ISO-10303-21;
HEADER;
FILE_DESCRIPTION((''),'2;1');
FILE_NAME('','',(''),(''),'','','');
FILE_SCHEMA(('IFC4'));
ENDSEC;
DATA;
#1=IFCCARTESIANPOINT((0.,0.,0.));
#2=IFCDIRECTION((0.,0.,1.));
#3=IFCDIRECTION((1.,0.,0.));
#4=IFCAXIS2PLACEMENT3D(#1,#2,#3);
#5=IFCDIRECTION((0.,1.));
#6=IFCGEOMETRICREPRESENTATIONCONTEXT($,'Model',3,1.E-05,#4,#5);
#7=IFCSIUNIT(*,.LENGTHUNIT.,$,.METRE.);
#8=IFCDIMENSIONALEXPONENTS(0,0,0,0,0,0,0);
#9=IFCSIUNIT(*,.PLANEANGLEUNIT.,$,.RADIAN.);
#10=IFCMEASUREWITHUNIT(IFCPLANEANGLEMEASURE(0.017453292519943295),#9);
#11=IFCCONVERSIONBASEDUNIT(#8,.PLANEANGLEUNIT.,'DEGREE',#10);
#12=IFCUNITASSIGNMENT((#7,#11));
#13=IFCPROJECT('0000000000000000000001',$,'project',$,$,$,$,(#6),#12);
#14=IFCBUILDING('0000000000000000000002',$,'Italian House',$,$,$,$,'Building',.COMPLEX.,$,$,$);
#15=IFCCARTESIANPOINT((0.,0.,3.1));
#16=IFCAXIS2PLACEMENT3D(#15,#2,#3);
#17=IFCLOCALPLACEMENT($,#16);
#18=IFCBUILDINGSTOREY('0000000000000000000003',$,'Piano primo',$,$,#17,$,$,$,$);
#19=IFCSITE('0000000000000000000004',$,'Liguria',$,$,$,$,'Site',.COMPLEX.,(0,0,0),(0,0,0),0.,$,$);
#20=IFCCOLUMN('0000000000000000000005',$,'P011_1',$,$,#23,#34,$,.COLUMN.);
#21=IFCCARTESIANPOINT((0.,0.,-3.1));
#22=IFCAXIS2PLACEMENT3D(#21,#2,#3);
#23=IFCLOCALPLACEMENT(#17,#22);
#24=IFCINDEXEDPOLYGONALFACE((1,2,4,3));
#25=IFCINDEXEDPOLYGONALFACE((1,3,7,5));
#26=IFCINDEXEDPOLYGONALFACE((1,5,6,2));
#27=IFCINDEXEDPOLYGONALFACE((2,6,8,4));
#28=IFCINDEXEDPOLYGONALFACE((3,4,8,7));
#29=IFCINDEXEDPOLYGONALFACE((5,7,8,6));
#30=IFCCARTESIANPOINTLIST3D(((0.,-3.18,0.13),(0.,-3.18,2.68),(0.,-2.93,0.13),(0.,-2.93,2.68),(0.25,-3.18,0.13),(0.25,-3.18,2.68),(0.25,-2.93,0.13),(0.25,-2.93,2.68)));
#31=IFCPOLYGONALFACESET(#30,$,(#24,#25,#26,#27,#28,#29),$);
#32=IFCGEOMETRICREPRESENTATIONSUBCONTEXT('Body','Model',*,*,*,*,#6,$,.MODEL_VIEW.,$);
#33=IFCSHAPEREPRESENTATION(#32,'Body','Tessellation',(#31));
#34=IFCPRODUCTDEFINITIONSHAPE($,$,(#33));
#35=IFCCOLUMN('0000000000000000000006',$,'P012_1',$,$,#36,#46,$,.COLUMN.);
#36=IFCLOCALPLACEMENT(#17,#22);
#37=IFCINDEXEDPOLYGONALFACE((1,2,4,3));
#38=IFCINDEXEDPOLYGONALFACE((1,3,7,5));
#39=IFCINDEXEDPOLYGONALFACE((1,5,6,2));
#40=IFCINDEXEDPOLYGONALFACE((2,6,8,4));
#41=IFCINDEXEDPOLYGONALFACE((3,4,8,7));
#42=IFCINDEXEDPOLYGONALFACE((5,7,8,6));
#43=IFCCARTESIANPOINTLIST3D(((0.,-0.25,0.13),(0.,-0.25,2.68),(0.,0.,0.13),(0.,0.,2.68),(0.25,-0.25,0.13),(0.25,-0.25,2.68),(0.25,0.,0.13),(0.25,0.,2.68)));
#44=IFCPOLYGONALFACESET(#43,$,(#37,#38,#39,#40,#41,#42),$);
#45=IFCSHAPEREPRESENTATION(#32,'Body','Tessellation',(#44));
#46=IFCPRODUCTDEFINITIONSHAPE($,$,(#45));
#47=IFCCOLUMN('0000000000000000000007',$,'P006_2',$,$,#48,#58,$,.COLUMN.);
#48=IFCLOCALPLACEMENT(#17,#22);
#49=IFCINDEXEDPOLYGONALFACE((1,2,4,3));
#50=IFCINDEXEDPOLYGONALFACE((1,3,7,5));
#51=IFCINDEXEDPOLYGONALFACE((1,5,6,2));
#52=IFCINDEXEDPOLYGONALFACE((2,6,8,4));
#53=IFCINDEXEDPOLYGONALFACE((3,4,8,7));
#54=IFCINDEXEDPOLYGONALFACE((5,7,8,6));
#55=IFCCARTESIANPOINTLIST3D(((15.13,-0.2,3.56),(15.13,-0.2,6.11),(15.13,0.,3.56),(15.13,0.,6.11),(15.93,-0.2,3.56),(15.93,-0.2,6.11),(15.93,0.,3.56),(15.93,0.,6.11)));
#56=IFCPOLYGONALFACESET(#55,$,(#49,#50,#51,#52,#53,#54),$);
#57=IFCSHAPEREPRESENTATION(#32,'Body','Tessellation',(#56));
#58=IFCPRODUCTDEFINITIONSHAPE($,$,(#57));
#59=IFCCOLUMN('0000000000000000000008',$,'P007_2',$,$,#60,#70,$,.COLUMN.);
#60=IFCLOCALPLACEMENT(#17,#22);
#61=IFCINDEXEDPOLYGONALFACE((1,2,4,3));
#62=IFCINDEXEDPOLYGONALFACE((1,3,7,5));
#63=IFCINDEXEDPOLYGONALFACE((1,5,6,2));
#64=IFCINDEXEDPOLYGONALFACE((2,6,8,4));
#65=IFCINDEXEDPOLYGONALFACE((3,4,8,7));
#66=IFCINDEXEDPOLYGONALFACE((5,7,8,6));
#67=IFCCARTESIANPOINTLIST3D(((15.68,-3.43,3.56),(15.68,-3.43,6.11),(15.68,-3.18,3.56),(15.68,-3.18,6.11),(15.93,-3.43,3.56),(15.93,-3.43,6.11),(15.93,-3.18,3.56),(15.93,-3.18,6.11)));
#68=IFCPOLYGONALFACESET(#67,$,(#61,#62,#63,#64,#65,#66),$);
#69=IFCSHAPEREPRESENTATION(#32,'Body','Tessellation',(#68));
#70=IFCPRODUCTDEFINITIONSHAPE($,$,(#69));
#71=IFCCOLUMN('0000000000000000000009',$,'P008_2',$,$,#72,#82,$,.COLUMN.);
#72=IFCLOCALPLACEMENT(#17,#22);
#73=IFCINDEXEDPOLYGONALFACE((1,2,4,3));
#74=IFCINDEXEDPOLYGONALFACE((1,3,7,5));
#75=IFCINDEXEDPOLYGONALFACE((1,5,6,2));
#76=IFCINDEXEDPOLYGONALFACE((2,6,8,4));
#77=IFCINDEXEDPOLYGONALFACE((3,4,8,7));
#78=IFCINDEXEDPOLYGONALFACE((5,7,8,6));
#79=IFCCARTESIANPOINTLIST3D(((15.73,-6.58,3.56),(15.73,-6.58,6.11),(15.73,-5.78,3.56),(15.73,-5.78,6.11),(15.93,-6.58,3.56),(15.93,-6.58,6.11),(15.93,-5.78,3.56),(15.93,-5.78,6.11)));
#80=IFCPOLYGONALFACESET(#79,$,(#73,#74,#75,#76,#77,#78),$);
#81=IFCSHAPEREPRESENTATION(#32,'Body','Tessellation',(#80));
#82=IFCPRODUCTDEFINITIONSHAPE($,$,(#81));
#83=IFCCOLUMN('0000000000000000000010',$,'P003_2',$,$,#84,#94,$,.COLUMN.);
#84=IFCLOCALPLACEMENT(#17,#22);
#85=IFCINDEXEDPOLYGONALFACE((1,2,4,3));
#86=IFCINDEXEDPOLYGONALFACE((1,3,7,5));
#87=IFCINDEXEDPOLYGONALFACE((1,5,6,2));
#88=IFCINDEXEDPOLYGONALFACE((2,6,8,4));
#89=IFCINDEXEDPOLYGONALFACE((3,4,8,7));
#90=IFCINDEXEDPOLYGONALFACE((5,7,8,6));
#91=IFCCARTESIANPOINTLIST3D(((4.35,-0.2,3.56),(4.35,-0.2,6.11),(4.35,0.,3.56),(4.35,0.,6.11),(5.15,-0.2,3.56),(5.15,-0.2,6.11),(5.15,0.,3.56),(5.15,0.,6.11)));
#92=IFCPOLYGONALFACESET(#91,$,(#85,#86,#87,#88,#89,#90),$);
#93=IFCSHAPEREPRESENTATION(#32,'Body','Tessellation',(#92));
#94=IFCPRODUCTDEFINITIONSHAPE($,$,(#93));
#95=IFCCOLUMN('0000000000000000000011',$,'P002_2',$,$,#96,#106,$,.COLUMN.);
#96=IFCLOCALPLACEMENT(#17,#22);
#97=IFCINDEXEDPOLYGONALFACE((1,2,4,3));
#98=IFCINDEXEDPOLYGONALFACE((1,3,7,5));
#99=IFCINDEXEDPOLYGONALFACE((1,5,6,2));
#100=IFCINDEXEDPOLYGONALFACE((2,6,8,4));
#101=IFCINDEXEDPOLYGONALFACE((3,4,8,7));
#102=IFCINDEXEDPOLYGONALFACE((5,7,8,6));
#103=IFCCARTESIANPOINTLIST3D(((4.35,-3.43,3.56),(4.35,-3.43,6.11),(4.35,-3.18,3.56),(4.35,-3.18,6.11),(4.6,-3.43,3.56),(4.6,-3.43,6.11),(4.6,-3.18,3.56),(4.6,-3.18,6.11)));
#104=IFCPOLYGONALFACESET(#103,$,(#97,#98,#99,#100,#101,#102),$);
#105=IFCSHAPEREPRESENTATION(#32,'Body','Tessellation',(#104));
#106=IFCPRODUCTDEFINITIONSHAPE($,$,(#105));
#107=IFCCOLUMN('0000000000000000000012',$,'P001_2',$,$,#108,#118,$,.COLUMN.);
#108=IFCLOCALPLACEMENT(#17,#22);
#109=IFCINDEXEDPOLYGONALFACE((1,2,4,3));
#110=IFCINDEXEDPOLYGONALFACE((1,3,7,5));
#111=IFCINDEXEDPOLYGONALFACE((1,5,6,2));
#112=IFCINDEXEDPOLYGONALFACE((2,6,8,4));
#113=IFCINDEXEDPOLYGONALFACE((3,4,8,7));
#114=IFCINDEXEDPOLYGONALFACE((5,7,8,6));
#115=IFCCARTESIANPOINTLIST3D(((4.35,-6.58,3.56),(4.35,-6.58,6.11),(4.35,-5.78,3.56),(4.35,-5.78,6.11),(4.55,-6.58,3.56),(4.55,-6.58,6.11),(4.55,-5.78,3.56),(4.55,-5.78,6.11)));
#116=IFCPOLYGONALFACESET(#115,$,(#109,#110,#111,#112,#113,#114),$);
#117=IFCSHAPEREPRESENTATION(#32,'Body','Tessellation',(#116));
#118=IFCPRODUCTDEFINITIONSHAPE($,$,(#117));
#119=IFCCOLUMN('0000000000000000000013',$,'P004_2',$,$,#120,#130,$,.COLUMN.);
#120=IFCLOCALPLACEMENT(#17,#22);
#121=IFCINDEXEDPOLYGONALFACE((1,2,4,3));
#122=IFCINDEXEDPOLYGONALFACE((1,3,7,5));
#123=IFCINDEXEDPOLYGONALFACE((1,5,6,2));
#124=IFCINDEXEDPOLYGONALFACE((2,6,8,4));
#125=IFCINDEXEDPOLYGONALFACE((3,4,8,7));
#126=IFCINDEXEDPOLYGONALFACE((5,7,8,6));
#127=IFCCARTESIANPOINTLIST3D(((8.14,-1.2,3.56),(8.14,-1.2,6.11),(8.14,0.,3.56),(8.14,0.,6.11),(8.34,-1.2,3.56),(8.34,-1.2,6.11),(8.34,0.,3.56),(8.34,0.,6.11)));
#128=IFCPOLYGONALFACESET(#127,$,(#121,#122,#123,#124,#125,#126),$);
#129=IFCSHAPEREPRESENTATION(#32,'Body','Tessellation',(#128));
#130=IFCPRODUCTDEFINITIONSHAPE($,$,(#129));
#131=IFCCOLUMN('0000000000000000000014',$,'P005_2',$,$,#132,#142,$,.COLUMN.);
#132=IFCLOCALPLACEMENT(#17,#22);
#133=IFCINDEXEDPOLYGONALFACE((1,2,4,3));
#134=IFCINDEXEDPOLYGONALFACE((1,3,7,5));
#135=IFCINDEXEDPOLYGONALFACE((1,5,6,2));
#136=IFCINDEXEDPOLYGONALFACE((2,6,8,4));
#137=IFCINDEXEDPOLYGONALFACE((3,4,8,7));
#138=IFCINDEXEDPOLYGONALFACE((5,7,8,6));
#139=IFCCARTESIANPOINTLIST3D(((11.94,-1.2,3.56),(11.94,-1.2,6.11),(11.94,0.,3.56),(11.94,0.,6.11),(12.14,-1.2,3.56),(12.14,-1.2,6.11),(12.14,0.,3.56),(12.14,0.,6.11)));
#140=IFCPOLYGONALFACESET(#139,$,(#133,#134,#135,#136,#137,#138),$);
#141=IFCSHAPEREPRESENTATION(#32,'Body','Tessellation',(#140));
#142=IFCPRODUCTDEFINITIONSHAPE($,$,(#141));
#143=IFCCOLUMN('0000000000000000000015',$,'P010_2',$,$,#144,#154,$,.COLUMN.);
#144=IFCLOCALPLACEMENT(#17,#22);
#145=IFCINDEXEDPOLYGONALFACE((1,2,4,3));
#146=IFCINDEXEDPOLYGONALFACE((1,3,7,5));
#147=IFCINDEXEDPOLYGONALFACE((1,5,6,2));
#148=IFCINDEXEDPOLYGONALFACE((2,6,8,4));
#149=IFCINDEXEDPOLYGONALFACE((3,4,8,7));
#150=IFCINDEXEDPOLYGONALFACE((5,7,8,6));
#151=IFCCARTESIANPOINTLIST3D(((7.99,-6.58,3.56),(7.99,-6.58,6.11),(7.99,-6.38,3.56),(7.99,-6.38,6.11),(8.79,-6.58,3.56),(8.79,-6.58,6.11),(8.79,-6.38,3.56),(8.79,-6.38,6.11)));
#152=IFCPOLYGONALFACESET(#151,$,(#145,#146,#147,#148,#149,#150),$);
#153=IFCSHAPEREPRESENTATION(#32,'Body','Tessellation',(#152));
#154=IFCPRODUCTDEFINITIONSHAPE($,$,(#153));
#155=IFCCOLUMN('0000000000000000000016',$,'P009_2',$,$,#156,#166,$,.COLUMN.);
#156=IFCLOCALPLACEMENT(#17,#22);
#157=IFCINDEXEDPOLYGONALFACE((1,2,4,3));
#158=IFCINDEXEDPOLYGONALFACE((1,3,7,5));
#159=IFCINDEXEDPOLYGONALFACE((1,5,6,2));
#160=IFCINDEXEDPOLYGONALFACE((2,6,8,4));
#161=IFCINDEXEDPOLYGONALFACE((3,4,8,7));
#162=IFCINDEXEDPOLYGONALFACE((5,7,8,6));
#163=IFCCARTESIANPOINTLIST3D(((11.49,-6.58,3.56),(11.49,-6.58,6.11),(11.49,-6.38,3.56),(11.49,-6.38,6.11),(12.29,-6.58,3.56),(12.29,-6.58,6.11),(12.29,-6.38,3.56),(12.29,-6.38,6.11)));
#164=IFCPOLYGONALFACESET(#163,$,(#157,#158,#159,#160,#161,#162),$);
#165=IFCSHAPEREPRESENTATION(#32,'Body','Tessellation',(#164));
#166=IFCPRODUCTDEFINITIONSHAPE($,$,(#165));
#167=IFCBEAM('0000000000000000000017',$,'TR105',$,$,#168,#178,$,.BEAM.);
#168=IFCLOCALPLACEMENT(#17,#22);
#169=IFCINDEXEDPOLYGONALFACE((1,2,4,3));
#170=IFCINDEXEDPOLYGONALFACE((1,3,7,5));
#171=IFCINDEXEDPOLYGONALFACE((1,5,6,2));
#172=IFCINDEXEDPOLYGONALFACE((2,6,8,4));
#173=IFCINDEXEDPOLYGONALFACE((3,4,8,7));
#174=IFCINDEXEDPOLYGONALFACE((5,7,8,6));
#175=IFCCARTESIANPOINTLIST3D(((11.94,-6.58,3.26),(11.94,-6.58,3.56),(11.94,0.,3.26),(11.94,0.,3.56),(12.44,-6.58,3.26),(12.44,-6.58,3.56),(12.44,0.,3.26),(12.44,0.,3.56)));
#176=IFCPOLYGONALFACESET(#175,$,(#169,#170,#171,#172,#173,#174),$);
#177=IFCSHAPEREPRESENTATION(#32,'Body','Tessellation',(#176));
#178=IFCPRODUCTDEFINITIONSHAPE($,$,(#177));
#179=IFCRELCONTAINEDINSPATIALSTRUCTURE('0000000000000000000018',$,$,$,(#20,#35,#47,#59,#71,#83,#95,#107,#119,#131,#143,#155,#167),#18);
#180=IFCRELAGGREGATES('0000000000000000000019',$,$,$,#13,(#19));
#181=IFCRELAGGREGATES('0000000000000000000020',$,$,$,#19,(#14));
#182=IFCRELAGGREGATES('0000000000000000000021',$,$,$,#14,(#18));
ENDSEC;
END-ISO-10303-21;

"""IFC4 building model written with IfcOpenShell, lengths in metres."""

from ifc_helpers import new_model, entity, si_unit, converted_unit, direction, frame, frame_2d, origin_with_axes, place, context, subcontext, project, spatial, rectangle, extrude, element, save


model = new_model("IFC4")

# Units and contexts
model_context = context("Model", 3, precision=1e-05, world=origin_with_axes(), true_north=direction((0.0, 1.0)))
body_context = subcontext(model_context, "Body", "Model", "MODEL_VIEW")
ifc_project = project(units=[si_unit("LENGTHUNIT", "METRE"), converted_unit("PLANEANGLEUNIT", "DEGREE", entity("IfcPlaneAngleMeasure", 0.017453292519943295), si_unit("PLANEANGLEUNIT", "RADIAN"), dimensions=[0, 0, 0, 0, 0, 0, 0])], contexts=[model_context])

# Site, building, storey
site = spatial("IfcSite", under=ifc_project, Name="Liguria", LongName="Site", CompositionType="COMPLEX", RefLatitude=(0, 0, 0), RefLongitude=(0, 0, 0), RefElevation=0.0)
building = spatial("IfcBuilding", under=site, Name="Italian House", LongName="Building", CompositionType="COMPLEX")
storey_placement = place(None, frame((0.0, 0.0, 3.1), z_axis=(0.0, 0.0, 1.0), x_axis=(1.0, 0.0, 0.0)))
storey = spatial("IfcBuildingStorey", under=building, at=storey_placement, Name="Piano primo")

# Columns
column_1_placement = place(storey_placement, frame((0.0, 0.0, -3.1), z_axis=(0.0, 0.0, 1.0), x_axis=(1.0, 0.0, 0.0)))
element("IfcColumn", 1, at=column_1_placement, inside=storey, Name="P011_1", PredefinedType="COLUMN", context=body_context, shape_type="SweptSolid", body=[
    extrude(rectangle(XDim=0.25, YDim=0.25, at=frame_2d((0.0, 0.0), x_axis=(1.0, 0.0))), frame((0.125, -3.055, 0.13), z_axis=(0.0, 0.0, 1.0), x_axis=(1.0, 0.0, 0.0)), (0.0, 0.0, 1.0), 2.55),
])
column_2_placement = place(storey_placement, frame((0.0, 0.0, -3.1), z_axis=(0.0, 0.0, 1.0), x_axis=(1.0, 0.0, 0.0)))
element("IfcColumn", 2, at=column_2_placement, inside=storey, Name="P012_1", PredefinedType="COLUMN", context=body_context, shape_type="SweptSolid", body=[
    extrude(rectangle(XDim=0.25, YDim=0.25, at=frame_2d((0.0, 0.0), x_axis=(1.0, 0.0))), frame((0.125, -0.125, 0.13), z_axis=(0.0, 0.0, 1.0), x_axis=(1.0, 0.0, 0.0)), (0.0, 0.0, 1.0), 2.55),
])
column_3_placement = place(storey_placement, frame((0.0, 0.0, -3.1), z_axis=(0.0, 0.0, 1.0), x_axis=(1.0, 0.0, 0.0)))
element("IfcColumn", 3, at=column_3_placement, inside=storey, Name="P006_2", PredefinedType="COLUMN", context=body_context, shape_type="SweptSolid", body=[
    extrude(rectangle(XDim=0.8, YDim=0.2, at=frame_2d((0.0, 0.0), x_axis=(1.0, 0.0))), frame((15.53, -0.1, 3.56), z_axis=(0.0, 0.0, 1.0), x_axis=(1.0, 0.0, 0.0)), (0.0, 0.0, 1.0), 2.55),
])
column_4_placement = place(storey_placement, frame((0.0, 0.0, -3.1), z_axis=(0.0, 0.0, 1.0), x_axis=(1.0, 0.0, 0.0)))
element("IfcColumn", 4, at=column_4_placement, inside=storey, Name="P007_2", PredefinedType="COLUMN", context=body_context, shape_type="SweptSolid", body=[
    extrude(rectangle(XDim=0.25, YDim=0.25, at=frame_2d((0.0, 0.0), x_axis=(1.0, 0.0))), frame((15.805, -3.305, 3.56), z_axis=(0.0, 0.0, 1.0), x_axis=(1.0, 0.0, 0.0)), (0.0, 0.0, 1.0), 2.55),
])
column_5_placement = place(storey_placement, frame((0.0, 0.0, -3.1), z_axis=(0.0, 0.0, 1.0), x_axis=(1.0, 0.0, 0.0)))
element("IfcColumn", 5, at=column_5_placement, inside=storey, Name="P008_2", PredefinedType="COLUMN", context=body_context, shape_type="SweptSolid", body=[
    extrude(rectangle(XDim=0.2, YDim=0.8, at=frame_2d((0.0, 0.0), x_axis=(1.0, 0.0))), frame((15.83, -6.18, 3.56), z_axis=(0.0, 0.0, 1.0), x_axis=(1.0, 0.0, 0.0)), (0.0, 0.0, 1.0), 2.55),
])
column_6_placement = place(storey_placement, frame((0.0, 0.0, -3.1), z_axis=(0.0, 0.0, 1.0), x_axis=(1.0, 0.0, 0.0)))
element("IfcColumn", 6, at=column_6_placement, inside=storey, Name="P003_2", PredefinedType="COLUMN", context=body_context, shape_type="SweptSolid", body=[
    extrude(rectangle(XDim=0.8, YDim=0.2, at=frame_2d((0.0, 0.0), x_axis=(1.0, 0.0))), frame((4.75, -0.1, 3.56), z_axis=(0.0, 0.0, 1.0), x_axis=(1.0, 0.0, 0.0)), (0.0, 0.0, 1.0), 2.55),
])
column_7_placement = place(storey_placement, frame((0.0, 0.0, -3.1), z_axis=(0.0, 0.0, 1.0), x_axis=(1.0, 0.0, 0.0)))
element("IfcColumn", 7, at=column_7_placement, inside=storey, Name="P002_2", PredefinedType="COLUMN", context=body_context, shape_type="SweptSolid", body=[
    extrude(rectangle(XDim=0.25, YDim=0.25, at=frame_2d((0.0, 0.0), x_axis=(1.0, 0.0))), frame((4.475, -3.305, 3.56), z_axis=(0.0, 0.0, 1.0), x_axis=(1.0, 0.0, 0.0)), (0.0, 0.0, 1.0), 2.55),
])
column_8_placement = place(storey_placement, frame((0.0, 0.0, -3.1), z_axis=(0.0, 0.0, 1.0), x_axis=(1.0, 0.0, 0.0)))
element("IfcColumn", 8, at=column_8_placement, inside=storey, Name="P001_2", PredefinedType="COLUMN", context=body_context, shape_type="SweptSolid", body=[
    extrude(rectangle(XDim=0.2, YDim=0.8, at=frame_2d((0.0, 0.0), x_axis=(1.0, 0.0))), frame((4.45, -6.18, 3.56), z_axis=(0.0, 0.0, 1.0), x_axis=(1.0, 0.0, 0.0)), (0.0, 0.0, 1.0), 2.55),
])
column_9_placement = place(storey_placement, frame((0.0, 0.0, -3.1), z_axis=(0.0, 0.0, 1.0), x_axis=(1.0, 0.0, 0.0)))
element("IfcColumn", 9, at=column_9_placement, inside=storey, Name="P004_2", PredefinedType="COLUMN", context=body_context, shape_type="SweptSolid", body=[
    extrude(rectangle(XDim=0.2, YDim=1.2, at=frame_2d((0.0, 0.0), x_axis=(1.0, 0.0))), frame((8.24, -0.6, 3.56), z_axis=(0.0, 0.0, 1.0), x_axis=(1.0, 0.0, 0.0)), (0.0, 0.0, 1.0), 2.55),
])
column_10_placement = place(storey_placement, frame((0.0, 0.0, -3.1), z_axis=(0.0, 0.0, 1.0), x_axis=(1.0, 0.0, 0.0)))
element("IfcColumn", 10, at=column_10_placement, inside=storey, Name="P005_2", PredefinedType="COLUMN", context=body_context, shape_type="SweptSolid", body=[
    extrude(rectangle(XDim=0.2, YDim=1.2, at=frame_2d((0.0, 0.0), x_axis=(1.0, 0.0))), frame((12.04, -0.6, 3.56), z_axis=(0.0, 0.0, 1.0), x_axis=(1.0, 0.0, 0.0)), (0.0, 0.0, 1.0), 2.55),
])
column_11_placement = place(storey_placement, frame((0.0, 0.0, -3.1), z_axis=(0.0, 0.0, 1.0), x_axis=(1.0, 0.0, 0.0)))
element("IfcColumn", 11, at=column_11_placement, inside=storey, Name="P010_2", PredefinedType="COLUMN", context=body_context, shape_type="SweptSolid", body=[
    extrude(rectangle(XDim=0.8, YDim=0.2, at=frame_2d((0.0, 0.0), x_axis=(1.0, 0.0))), frame((8.39, -6.48, 3.56), z_axis=(0.0, 0.0, 1.0), x_axis=(1.0, 0.0, 0.0)), (0.0, 0.0, 1.0), 2.55),
])
column_12_placement = place(storey_placement, frame((0.0, 0.0, -3.1), z_axis=(0.0, 0.0, 1.0), x_axis=(1.0, 0.0, 0.0)))
element("IfcColumn", 12, at=column_12_placement, inside=storey, Name="P009_2", PredefinedType="COLUMN", context=body_context, shape_type="SweptSolid", body=[
    extrude(rectangle(XDim=0.8, YDim=0.2, at=frame_2d((0.0, 0.0), x_axis=(1.0, 0.0))), frame((11.89, -6.48, 3.56), z_axis=(0.0, 0.0, 1.0), x_axis=(1.0, 0.0, 0.0)), (0.0, 0.0, 1.0), 2.55),
])

# Beam
beam_1_placement = place(storey_placement, frame((0.0, 0.0, -3.1), z_axis=(0.0, 0.0, 1.0), x_axis=(1.0, 0.0, 0.0)))
element("IfcBeam", 13, at=beam_1_placement, inside=storey, Name="TR105", PredefinedType="BEAM", context=body_context, shape_type="SweptSolid", body=[
    extrude(rectangle(XDim=0.5, YDim=0.3, at=frame_2d((0.0, 0.0), x_axis=(0.0, 1.0))), frame((12.19, -6.58, 3.41), z_axis=(0.0, 1.0, 0.0), x_axis=(0.0, 0.0, -1.0)), (0.0, 0.0, 1.0), 6.58),
])

save(model, "model.ifc")
